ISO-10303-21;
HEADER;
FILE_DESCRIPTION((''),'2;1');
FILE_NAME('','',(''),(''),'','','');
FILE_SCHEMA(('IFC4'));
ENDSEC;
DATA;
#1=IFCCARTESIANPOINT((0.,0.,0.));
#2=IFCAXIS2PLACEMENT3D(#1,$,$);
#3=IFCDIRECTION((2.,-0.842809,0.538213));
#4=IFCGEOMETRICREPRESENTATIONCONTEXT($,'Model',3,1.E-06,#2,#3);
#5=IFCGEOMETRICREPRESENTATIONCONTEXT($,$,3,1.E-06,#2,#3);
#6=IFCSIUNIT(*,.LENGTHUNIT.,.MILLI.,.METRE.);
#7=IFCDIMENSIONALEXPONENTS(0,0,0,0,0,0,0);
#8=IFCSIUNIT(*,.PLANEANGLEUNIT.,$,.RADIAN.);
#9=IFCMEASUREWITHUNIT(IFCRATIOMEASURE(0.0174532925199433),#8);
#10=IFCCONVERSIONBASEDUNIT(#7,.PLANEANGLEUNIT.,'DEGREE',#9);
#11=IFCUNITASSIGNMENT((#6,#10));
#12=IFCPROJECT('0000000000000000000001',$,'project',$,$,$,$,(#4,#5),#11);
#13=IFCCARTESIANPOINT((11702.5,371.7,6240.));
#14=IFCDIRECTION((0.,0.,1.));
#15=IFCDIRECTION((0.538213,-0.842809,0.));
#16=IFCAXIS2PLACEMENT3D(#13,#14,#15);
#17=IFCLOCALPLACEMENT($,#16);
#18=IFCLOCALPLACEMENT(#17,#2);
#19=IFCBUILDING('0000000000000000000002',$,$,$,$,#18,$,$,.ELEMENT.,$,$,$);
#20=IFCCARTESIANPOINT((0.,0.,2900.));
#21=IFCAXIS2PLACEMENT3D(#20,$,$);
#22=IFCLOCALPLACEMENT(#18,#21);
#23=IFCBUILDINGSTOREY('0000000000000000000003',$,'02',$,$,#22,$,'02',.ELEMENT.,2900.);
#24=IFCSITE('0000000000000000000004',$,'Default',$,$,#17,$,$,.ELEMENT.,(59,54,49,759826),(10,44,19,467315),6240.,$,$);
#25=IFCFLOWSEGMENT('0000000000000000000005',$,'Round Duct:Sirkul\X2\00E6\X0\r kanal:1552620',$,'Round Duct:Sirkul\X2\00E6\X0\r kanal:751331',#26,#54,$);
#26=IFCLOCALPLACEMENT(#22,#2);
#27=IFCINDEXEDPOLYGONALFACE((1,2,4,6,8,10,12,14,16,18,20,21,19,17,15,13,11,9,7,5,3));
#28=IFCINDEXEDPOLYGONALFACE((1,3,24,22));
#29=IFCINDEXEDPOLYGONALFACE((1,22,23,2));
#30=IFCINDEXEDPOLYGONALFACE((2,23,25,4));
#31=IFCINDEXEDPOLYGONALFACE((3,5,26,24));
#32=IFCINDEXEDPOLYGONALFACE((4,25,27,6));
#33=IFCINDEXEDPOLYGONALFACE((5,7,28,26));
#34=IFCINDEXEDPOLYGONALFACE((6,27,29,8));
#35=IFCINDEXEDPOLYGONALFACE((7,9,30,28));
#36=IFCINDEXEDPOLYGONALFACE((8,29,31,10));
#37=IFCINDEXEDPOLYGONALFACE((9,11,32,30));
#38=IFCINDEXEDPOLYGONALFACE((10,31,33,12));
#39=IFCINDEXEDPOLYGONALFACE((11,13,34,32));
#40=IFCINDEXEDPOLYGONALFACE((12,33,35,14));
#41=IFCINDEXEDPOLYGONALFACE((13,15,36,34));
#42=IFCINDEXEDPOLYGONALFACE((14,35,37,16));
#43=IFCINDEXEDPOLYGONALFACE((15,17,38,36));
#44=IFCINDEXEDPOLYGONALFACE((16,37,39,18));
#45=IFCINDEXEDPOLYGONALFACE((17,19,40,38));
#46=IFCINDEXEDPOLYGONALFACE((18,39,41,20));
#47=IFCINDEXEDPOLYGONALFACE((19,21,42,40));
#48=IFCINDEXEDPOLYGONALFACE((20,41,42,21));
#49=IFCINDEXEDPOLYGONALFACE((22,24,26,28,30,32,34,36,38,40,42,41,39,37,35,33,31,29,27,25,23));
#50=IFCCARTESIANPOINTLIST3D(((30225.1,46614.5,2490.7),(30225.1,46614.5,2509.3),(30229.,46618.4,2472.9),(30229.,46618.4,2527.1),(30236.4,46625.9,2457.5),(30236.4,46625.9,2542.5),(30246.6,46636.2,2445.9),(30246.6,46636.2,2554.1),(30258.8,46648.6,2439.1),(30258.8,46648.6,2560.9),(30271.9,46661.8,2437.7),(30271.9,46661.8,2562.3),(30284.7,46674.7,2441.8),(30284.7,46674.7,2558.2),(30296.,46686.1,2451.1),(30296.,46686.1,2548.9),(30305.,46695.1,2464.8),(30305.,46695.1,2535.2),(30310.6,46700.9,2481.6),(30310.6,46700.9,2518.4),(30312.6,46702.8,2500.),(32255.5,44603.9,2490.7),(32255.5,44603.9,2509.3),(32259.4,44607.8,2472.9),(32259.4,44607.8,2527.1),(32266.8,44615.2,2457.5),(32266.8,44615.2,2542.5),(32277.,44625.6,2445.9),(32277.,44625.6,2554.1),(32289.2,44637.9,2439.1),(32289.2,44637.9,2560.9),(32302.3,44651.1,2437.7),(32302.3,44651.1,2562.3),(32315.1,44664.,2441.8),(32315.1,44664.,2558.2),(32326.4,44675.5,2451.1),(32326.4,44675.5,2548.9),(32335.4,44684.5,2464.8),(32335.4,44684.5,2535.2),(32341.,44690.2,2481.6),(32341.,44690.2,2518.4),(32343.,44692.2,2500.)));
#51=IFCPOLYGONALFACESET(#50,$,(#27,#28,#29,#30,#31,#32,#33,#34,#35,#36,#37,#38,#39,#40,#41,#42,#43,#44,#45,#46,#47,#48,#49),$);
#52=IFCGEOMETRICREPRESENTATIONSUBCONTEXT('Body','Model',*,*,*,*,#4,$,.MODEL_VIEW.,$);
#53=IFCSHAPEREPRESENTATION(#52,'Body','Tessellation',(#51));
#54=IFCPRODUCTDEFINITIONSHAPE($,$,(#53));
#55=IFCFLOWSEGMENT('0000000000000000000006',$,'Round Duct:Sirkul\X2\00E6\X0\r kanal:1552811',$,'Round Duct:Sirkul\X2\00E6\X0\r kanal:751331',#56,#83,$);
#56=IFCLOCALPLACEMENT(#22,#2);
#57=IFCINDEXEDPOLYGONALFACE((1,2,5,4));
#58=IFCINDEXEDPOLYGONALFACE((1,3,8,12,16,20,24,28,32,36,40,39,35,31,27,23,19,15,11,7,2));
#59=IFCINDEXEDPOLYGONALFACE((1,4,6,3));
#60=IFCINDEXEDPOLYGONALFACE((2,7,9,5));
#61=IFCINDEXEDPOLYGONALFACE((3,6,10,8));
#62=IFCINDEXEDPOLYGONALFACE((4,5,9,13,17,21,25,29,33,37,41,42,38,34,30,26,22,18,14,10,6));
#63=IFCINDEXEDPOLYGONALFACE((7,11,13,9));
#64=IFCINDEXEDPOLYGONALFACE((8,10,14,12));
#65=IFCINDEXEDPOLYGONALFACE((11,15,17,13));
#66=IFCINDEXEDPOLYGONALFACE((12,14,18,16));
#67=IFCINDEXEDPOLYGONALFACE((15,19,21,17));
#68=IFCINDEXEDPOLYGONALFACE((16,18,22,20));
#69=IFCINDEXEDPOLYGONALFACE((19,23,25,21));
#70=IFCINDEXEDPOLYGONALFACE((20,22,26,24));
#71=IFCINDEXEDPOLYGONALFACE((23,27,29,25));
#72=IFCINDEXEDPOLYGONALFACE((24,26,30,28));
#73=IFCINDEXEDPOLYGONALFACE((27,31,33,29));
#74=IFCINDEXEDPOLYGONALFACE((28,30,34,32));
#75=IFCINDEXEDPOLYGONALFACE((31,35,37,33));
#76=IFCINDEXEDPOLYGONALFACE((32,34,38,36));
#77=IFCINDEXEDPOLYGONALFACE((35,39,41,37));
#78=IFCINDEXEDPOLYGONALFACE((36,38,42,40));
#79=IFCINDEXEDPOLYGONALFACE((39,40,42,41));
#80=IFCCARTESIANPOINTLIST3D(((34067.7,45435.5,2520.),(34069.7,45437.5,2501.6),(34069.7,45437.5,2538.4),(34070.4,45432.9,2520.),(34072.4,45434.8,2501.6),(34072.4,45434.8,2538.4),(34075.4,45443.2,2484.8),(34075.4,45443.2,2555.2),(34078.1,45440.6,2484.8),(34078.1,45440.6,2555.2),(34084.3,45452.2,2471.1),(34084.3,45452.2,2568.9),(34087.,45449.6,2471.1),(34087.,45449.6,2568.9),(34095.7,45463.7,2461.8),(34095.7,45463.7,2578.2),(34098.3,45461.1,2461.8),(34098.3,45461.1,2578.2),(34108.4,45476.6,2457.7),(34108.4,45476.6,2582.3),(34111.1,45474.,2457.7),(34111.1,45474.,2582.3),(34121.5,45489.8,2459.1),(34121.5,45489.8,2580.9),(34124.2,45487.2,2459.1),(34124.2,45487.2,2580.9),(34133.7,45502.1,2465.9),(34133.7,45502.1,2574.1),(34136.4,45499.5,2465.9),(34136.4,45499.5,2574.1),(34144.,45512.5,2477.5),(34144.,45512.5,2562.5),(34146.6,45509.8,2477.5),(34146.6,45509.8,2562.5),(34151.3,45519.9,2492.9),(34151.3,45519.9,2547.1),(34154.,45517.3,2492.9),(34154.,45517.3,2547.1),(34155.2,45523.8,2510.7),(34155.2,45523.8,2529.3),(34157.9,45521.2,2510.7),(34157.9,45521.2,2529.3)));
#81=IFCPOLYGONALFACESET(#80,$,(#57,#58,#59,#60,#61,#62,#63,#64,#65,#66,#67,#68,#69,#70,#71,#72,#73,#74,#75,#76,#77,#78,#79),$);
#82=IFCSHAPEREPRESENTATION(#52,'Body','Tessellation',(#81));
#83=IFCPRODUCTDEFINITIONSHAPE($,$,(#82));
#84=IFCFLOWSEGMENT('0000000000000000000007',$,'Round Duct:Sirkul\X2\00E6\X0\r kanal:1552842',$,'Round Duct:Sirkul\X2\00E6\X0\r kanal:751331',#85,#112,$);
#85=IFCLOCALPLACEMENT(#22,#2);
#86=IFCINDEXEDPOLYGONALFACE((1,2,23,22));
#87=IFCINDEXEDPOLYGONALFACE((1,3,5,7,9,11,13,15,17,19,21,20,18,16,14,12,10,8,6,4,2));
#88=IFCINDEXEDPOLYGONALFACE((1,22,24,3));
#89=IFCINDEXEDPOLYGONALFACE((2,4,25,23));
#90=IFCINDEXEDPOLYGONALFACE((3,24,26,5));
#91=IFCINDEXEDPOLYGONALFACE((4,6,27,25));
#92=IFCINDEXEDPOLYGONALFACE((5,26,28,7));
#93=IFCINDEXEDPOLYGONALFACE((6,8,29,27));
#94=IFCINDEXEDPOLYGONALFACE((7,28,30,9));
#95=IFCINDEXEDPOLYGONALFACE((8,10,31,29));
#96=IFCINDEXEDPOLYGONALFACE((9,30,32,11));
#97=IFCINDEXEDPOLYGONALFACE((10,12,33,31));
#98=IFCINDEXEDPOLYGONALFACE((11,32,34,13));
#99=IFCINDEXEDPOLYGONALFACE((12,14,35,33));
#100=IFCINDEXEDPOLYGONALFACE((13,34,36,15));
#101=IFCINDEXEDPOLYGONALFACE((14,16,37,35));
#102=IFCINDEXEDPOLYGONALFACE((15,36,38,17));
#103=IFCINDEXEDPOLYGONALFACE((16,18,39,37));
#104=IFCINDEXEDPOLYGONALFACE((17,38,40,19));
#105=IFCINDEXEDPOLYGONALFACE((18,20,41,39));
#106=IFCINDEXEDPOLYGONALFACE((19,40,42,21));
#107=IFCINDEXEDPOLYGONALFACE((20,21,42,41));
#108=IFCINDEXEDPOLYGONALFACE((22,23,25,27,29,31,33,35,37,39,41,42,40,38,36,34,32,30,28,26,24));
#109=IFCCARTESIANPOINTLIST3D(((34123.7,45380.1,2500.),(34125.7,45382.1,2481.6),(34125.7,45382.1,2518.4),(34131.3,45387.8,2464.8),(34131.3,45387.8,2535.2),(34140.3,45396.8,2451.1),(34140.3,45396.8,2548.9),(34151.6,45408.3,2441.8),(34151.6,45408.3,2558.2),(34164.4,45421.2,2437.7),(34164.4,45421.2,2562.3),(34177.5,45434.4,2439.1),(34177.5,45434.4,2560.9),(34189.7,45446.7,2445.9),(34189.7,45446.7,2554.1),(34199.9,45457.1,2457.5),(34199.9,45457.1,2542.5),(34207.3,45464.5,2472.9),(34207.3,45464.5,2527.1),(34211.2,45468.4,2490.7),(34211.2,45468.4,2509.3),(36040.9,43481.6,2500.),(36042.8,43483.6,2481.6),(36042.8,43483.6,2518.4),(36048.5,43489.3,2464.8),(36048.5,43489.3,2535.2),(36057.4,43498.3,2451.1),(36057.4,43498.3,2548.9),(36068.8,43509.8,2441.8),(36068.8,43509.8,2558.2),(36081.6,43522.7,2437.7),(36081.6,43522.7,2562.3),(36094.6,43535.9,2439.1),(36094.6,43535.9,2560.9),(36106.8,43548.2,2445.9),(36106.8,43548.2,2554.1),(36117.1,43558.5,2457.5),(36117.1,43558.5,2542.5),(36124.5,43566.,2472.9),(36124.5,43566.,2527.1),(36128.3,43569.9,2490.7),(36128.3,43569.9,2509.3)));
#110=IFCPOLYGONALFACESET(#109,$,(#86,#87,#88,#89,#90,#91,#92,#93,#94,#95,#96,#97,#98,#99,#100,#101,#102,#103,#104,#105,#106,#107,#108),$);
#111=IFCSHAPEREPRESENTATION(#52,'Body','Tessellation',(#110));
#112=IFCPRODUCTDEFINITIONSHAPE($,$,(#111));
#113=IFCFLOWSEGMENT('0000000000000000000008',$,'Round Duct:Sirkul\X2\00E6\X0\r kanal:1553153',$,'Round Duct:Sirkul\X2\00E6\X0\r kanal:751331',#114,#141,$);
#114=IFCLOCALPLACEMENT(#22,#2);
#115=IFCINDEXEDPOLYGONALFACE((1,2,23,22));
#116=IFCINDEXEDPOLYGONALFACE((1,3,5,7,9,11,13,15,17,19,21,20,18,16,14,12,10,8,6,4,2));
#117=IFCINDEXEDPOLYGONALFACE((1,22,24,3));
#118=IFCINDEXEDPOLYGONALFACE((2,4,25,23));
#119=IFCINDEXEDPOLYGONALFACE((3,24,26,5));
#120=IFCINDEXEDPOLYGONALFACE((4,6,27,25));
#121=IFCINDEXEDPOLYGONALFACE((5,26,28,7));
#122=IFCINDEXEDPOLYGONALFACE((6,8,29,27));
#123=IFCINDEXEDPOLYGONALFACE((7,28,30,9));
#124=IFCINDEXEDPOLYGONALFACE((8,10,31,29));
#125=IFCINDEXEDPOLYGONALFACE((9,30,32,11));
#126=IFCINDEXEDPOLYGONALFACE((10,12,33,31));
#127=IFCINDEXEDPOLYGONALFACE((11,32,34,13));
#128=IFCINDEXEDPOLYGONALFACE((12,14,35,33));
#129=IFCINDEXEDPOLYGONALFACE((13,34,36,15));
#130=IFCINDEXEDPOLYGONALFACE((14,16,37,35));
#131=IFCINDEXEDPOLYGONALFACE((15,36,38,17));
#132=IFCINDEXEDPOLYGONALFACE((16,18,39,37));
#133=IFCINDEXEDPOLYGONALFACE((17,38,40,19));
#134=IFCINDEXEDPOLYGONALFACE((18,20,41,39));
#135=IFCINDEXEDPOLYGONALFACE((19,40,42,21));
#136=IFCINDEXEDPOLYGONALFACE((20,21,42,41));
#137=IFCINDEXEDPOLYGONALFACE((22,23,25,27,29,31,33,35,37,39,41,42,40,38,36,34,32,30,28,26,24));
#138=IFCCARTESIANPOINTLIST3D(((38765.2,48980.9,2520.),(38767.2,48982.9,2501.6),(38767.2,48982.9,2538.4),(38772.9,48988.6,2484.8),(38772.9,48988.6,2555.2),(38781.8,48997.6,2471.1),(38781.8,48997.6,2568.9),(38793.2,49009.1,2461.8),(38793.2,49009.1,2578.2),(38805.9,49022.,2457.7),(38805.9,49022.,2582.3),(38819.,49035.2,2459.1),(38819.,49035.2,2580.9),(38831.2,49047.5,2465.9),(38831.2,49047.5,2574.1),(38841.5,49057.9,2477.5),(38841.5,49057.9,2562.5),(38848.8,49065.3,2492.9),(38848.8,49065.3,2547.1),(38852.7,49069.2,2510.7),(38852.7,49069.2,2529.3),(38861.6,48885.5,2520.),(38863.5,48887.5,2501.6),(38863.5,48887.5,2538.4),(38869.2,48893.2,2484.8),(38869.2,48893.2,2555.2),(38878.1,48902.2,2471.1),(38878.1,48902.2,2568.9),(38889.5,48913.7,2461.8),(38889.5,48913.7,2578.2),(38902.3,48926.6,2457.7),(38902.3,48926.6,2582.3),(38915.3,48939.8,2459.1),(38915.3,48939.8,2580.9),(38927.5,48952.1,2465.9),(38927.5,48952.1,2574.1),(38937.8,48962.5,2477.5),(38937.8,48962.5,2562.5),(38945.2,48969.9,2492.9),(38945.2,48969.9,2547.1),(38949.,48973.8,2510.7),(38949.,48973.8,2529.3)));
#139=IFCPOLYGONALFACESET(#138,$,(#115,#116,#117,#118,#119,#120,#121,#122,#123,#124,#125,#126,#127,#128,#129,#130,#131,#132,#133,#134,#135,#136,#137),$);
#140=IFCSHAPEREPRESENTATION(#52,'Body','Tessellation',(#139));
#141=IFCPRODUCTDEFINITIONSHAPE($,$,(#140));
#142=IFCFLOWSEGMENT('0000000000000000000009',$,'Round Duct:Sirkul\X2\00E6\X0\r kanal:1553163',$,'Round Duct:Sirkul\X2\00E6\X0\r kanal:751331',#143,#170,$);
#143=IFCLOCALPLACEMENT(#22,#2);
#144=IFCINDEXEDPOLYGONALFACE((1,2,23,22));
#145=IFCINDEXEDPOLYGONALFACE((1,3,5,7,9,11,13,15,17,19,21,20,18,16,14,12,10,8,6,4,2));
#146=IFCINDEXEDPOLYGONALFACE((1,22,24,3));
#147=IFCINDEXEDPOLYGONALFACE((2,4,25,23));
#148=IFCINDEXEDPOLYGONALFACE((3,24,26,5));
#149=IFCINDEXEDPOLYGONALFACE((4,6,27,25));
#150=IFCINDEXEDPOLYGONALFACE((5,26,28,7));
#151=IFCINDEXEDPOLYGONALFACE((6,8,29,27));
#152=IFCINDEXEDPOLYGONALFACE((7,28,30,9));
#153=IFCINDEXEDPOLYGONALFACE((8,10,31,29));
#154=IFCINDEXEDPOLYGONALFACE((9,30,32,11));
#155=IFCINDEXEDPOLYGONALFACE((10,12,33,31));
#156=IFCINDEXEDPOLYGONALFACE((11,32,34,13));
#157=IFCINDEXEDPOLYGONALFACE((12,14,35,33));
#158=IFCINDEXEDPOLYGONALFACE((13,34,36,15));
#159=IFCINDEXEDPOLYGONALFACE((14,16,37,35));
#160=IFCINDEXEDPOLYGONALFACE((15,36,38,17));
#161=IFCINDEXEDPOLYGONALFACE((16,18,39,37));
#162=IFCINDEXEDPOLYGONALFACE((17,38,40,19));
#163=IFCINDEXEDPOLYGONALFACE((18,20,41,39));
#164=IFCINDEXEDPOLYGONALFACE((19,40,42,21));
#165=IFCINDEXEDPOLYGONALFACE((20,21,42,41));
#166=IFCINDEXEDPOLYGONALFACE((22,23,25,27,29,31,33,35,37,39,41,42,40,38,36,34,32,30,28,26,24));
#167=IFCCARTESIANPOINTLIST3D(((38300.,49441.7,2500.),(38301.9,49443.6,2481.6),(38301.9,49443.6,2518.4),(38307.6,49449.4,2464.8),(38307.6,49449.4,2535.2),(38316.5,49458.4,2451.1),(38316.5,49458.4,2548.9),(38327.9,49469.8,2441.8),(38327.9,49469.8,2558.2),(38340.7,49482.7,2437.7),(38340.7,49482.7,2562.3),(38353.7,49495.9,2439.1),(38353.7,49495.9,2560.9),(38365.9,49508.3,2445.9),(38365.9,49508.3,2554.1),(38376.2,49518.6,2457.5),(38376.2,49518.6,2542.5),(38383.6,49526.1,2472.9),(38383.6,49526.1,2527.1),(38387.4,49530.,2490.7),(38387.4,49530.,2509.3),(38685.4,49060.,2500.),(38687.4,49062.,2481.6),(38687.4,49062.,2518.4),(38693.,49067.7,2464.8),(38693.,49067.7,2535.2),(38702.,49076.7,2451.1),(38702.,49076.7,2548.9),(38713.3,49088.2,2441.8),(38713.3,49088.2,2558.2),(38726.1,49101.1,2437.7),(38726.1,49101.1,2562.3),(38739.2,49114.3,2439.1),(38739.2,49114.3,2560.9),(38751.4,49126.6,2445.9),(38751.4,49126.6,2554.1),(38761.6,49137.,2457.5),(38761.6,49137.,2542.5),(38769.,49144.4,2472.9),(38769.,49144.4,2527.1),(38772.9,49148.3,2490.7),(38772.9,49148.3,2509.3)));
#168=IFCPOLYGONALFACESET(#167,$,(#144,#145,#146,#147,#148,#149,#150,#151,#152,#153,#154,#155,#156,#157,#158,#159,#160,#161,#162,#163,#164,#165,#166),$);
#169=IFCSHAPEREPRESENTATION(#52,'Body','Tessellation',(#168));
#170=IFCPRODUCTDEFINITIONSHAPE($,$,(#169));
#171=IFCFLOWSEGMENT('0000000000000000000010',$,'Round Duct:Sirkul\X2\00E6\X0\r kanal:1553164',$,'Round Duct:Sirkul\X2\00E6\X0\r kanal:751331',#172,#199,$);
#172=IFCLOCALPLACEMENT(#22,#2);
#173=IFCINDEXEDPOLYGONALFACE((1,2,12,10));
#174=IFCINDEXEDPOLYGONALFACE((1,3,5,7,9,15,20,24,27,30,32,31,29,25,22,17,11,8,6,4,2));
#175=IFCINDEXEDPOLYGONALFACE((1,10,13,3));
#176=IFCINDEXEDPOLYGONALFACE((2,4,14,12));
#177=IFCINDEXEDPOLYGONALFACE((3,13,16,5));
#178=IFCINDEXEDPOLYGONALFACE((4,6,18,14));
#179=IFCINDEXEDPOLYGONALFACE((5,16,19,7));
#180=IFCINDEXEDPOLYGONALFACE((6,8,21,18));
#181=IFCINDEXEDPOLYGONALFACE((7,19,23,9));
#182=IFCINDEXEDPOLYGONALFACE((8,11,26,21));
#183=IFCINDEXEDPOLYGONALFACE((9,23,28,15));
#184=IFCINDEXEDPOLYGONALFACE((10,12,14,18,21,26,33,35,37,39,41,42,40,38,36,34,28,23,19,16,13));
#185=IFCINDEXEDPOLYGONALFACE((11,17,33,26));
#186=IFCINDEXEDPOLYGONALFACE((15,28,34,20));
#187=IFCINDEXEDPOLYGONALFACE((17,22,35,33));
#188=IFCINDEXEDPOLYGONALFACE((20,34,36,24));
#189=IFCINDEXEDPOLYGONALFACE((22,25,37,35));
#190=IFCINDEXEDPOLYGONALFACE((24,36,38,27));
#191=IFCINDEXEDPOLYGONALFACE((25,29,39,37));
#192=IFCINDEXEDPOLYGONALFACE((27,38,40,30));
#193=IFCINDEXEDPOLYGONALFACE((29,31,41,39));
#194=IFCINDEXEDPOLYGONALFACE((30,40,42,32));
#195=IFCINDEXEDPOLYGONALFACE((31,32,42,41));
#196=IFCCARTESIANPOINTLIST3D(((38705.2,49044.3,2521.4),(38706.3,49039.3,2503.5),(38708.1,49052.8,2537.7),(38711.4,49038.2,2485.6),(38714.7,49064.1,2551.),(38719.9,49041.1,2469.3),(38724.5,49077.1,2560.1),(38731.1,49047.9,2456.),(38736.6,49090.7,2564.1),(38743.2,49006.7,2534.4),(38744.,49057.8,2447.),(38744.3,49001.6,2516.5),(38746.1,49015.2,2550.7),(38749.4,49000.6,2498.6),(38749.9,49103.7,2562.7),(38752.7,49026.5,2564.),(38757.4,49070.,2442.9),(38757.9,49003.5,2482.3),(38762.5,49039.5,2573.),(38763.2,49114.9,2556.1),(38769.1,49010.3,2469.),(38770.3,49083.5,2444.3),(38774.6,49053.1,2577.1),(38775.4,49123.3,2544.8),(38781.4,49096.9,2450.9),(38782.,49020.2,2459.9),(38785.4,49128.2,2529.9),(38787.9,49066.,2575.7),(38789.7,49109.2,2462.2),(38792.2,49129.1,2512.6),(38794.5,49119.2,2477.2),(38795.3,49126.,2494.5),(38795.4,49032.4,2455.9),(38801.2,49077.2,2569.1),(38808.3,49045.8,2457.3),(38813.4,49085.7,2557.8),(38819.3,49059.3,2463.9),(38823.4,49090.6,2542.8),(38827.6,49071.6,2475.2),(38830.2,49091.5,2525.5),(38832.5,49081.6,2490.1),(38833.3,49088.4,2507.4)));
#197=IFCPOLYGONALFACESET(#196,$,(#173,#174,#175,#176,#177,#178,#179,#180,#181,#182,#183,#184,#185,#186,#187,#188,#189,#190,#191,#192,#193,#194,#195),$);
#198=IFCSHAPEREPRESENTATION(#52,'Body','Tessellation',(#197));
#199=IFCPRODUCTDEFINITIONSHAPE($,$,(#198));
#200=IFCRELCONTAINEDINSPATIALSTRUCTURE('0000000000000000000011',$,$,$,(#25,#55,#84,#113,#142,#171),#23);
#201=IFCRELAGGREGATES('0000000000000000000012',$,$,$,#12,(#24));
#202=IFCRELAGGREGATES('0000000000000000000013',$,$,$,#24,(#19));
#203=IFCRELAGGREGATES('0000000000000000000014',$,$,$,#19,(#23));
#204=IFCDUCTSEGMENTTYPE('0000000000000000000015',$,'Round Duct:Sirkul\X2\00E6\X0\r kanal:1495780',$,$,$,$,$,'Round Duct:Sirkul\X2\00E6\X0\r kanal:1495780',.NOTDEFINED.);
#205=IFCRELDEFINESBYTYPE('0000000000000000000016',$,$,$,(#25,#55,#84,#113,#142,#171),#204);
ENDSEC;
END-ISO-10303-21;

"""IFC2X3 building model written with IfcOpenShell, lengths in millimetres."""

from ifc_helpers import new_model, entity, si_unit, converted_unit, direction, frame, frame_2d, origin, origin_2d_with_axis, place, context, subcontext, project, spatial, circle, extrude, type_object, element, save


model = new_model("IFC2X3")

# Units and contexts
model_context = context("Model", 3, precision=1e-06, world=origin(), true_north=direction((2.0, -0.842809, 0.538213)))
context_of_model = context(None, 3, precision=1e-06, world=origin(), true_north=direction((2.0, -0.842809, 0.538213)))
body_context = subcontext(model_context, "Body", "Model", "MODEL_VIEW")
ifc_project = project(units=[si_unit("LENGTHUNIT", "METRE", prefix="MILLI"), converted_unit("PLANEANGLEUNIT", "DEGREE", entity("IfcRatioMeasure", 0.0174532925199433), si_unit("PLANEANGLEUNIT", "RADIAN"), dimensions=[0, 0, 0, 0, 0, 0, 0])], contexts=[model_context, context_of_model])

# Site, building, storey
site_placement = place(None, frame((11702.5, 371.7, 6240.0), z_axis=(0.0, 0.0, 1.0), x_axis=(0.538213, -0.842809, 0.0)))
site = spatial("IfcSite", under=ifc_project, at=site_placement, Name="Default", CompositionType="ELEMENT", RefLatitude=(59, 54, 49, 759826), RefLongitude=(10, 44, 19, 467315), RefElevation=6240.0)
building_placement = place(site_placement, origin())
building = spatial("IfcBuilding", under=site, at=building_placement, CompositionType="ELEMENT")
storey_placement = place(building_placement, frame((0.0, 0.0, 2900.0)))
storey = spatial("IfcBuildingStorey", under=building, at=storey_placement, Name="02", LongName="02", CompositionType="ELEMENT", Elevation=2900.0)

# Flow segments
duct_segment_type = type_object("IfcDuctSegmentType", Name="Round Duct:Sirkulær kanal:1495780", ElementType="Round Duct:Sirkulær kanal:1495780", PredefinedType="NOTDEFINED")
flow_segment_1_placement = place(storey_placement, origin())
element("IfcFlowSegment", 1, at=flow_segment_1_placement, inside=storey, type_object=duct_segment_type, Name="Round Duct:Sirkulær kanal:1552620", ObjectType="Round Duct:Sirkulær kanal:751331", context=body_context, shape_type="SweptSolid", body=[
    extrude(circle(Radius=62.5, at=origin_2d_with_axis()), frame((32299.0, 44647.8, 2500.0), z_axis=(-0.710554, 0.703643, 0.0), x_axis=(0.703643, 0.710554, 0.0)), (0.0, 0.0, 1.0), 2857.5),
])
flow_segment_2_placement = place(storey_placement, origin())
element("IfcFlowSegment", 2, at=flow_segment_2_placement, inside=storey, type_object=duct_segment_type, Name="Round Duct:Sirkulær kanal:1552811", ObjectType="Round Duct:Sirkulær kanal:751331", context=body_context, shape_type="SweptSolid", body=[
    extrude(circle(Radius=62.5, at=origin_2d_with_axis()), frame((34111.7, 45479.9, 2520.0), z_axis=(0.710554, -0.703643, 0.0), x_axis=(-0.703643, -0.710554, 0.0)), (0.0, 0.0, 1.0), 3.7),
])
flow_segment_3_placement = place(storey_placement, origin())
element("IfcFlowSegment", 3, at=flow_segment_3_placement, inside=storey, type_object=duct_segment_type, Name="Round Duct:Sirkulær kanal:1552842", ObjectType="Round Duct:Sirkulær kanal:751331", context=body_context, shape_type="SweptSolid", body=[
    extrude(circle(Radius=62.5, at=frame_2d((0.0, 0.0), x_axis=(1.0, 0.0))), frame((36084.8, 43526.0, 2500.0), z_axis=(-0.710554, 0.703643, 0.0), x_axis=(-0.703643, -0.710554, 0.0)), (0.0, 0.0, 1.0), 2698.1),
])
flow_segment_4_placement = place(storey_placement, origin())
element("IfcFlowSegment", 4, at=flow_segment_4_placement, inside=storey, type_object=duct_segment_type, Name="Round Duct:Sirkulær kanal:1553153", ObjectType="Round Duct:Sirkulær kanal:751331", context=body_context, shape_type="SweptSolid", body=[
    extrude(circle(Radius=62.5, at=origin_2d_with_axis()), frame((38905.6, 48929.9, 2520.0), z_axis=(-0.710554, 0.703643, 0.0), x_axis=(-0.703643, -0.710554, 0.0)), (0.0, 0.0, 1.0), 135.6),
])
flow_segment_5_placement = place(storey_placement, origin())
element("IfcFlowSegment", 5, at=flow_segment_5_placement, inside=storey, type_object=duct_segment_type, Name="Round Duct:Sirkulær kanal:1553163", ObjectType="Round Duct:Sirkulær kanal:751331", context=body_context, shape_type="SweptSolid", body=[
    extrude(circle(Radius=62.5, at=origin_2d_with_axis()), frame((38729.4, 49104.4, 2500.0), z_axis=(-0.710554, 0.703643, 0.0), x_axis=(-0.703643, -0.710554, 0.0)), (0.0, 0.0, 1.0), 542.4),
])
flow_segment_6_placement = place(storey_placement, origin())
element("IfcFlowSegment", 6, at=flow_segment_6_placement, inside=storey, type_object=duct_segment_type, Name="Round Duct:Sirkulær kanal:1553164", ObjectType="Round Duct:Sirkulær kanal:751331", context=body_context, shape_type="SweptSolid", body=[
    extrude(circle(Radius=62.5, at=frame_2d((0.0, 0.0), x_axis=(1.0, 0.0))), frame((38750.3, 49083.7, 2503.5), z_axis=(0.690552, -0.683835, 0.2356), x_axis=(-0.703643, -0.710554, 0.0)), (0.0, 0.0, 1.0), 55.0),
])

save(model, "model.ifc")
